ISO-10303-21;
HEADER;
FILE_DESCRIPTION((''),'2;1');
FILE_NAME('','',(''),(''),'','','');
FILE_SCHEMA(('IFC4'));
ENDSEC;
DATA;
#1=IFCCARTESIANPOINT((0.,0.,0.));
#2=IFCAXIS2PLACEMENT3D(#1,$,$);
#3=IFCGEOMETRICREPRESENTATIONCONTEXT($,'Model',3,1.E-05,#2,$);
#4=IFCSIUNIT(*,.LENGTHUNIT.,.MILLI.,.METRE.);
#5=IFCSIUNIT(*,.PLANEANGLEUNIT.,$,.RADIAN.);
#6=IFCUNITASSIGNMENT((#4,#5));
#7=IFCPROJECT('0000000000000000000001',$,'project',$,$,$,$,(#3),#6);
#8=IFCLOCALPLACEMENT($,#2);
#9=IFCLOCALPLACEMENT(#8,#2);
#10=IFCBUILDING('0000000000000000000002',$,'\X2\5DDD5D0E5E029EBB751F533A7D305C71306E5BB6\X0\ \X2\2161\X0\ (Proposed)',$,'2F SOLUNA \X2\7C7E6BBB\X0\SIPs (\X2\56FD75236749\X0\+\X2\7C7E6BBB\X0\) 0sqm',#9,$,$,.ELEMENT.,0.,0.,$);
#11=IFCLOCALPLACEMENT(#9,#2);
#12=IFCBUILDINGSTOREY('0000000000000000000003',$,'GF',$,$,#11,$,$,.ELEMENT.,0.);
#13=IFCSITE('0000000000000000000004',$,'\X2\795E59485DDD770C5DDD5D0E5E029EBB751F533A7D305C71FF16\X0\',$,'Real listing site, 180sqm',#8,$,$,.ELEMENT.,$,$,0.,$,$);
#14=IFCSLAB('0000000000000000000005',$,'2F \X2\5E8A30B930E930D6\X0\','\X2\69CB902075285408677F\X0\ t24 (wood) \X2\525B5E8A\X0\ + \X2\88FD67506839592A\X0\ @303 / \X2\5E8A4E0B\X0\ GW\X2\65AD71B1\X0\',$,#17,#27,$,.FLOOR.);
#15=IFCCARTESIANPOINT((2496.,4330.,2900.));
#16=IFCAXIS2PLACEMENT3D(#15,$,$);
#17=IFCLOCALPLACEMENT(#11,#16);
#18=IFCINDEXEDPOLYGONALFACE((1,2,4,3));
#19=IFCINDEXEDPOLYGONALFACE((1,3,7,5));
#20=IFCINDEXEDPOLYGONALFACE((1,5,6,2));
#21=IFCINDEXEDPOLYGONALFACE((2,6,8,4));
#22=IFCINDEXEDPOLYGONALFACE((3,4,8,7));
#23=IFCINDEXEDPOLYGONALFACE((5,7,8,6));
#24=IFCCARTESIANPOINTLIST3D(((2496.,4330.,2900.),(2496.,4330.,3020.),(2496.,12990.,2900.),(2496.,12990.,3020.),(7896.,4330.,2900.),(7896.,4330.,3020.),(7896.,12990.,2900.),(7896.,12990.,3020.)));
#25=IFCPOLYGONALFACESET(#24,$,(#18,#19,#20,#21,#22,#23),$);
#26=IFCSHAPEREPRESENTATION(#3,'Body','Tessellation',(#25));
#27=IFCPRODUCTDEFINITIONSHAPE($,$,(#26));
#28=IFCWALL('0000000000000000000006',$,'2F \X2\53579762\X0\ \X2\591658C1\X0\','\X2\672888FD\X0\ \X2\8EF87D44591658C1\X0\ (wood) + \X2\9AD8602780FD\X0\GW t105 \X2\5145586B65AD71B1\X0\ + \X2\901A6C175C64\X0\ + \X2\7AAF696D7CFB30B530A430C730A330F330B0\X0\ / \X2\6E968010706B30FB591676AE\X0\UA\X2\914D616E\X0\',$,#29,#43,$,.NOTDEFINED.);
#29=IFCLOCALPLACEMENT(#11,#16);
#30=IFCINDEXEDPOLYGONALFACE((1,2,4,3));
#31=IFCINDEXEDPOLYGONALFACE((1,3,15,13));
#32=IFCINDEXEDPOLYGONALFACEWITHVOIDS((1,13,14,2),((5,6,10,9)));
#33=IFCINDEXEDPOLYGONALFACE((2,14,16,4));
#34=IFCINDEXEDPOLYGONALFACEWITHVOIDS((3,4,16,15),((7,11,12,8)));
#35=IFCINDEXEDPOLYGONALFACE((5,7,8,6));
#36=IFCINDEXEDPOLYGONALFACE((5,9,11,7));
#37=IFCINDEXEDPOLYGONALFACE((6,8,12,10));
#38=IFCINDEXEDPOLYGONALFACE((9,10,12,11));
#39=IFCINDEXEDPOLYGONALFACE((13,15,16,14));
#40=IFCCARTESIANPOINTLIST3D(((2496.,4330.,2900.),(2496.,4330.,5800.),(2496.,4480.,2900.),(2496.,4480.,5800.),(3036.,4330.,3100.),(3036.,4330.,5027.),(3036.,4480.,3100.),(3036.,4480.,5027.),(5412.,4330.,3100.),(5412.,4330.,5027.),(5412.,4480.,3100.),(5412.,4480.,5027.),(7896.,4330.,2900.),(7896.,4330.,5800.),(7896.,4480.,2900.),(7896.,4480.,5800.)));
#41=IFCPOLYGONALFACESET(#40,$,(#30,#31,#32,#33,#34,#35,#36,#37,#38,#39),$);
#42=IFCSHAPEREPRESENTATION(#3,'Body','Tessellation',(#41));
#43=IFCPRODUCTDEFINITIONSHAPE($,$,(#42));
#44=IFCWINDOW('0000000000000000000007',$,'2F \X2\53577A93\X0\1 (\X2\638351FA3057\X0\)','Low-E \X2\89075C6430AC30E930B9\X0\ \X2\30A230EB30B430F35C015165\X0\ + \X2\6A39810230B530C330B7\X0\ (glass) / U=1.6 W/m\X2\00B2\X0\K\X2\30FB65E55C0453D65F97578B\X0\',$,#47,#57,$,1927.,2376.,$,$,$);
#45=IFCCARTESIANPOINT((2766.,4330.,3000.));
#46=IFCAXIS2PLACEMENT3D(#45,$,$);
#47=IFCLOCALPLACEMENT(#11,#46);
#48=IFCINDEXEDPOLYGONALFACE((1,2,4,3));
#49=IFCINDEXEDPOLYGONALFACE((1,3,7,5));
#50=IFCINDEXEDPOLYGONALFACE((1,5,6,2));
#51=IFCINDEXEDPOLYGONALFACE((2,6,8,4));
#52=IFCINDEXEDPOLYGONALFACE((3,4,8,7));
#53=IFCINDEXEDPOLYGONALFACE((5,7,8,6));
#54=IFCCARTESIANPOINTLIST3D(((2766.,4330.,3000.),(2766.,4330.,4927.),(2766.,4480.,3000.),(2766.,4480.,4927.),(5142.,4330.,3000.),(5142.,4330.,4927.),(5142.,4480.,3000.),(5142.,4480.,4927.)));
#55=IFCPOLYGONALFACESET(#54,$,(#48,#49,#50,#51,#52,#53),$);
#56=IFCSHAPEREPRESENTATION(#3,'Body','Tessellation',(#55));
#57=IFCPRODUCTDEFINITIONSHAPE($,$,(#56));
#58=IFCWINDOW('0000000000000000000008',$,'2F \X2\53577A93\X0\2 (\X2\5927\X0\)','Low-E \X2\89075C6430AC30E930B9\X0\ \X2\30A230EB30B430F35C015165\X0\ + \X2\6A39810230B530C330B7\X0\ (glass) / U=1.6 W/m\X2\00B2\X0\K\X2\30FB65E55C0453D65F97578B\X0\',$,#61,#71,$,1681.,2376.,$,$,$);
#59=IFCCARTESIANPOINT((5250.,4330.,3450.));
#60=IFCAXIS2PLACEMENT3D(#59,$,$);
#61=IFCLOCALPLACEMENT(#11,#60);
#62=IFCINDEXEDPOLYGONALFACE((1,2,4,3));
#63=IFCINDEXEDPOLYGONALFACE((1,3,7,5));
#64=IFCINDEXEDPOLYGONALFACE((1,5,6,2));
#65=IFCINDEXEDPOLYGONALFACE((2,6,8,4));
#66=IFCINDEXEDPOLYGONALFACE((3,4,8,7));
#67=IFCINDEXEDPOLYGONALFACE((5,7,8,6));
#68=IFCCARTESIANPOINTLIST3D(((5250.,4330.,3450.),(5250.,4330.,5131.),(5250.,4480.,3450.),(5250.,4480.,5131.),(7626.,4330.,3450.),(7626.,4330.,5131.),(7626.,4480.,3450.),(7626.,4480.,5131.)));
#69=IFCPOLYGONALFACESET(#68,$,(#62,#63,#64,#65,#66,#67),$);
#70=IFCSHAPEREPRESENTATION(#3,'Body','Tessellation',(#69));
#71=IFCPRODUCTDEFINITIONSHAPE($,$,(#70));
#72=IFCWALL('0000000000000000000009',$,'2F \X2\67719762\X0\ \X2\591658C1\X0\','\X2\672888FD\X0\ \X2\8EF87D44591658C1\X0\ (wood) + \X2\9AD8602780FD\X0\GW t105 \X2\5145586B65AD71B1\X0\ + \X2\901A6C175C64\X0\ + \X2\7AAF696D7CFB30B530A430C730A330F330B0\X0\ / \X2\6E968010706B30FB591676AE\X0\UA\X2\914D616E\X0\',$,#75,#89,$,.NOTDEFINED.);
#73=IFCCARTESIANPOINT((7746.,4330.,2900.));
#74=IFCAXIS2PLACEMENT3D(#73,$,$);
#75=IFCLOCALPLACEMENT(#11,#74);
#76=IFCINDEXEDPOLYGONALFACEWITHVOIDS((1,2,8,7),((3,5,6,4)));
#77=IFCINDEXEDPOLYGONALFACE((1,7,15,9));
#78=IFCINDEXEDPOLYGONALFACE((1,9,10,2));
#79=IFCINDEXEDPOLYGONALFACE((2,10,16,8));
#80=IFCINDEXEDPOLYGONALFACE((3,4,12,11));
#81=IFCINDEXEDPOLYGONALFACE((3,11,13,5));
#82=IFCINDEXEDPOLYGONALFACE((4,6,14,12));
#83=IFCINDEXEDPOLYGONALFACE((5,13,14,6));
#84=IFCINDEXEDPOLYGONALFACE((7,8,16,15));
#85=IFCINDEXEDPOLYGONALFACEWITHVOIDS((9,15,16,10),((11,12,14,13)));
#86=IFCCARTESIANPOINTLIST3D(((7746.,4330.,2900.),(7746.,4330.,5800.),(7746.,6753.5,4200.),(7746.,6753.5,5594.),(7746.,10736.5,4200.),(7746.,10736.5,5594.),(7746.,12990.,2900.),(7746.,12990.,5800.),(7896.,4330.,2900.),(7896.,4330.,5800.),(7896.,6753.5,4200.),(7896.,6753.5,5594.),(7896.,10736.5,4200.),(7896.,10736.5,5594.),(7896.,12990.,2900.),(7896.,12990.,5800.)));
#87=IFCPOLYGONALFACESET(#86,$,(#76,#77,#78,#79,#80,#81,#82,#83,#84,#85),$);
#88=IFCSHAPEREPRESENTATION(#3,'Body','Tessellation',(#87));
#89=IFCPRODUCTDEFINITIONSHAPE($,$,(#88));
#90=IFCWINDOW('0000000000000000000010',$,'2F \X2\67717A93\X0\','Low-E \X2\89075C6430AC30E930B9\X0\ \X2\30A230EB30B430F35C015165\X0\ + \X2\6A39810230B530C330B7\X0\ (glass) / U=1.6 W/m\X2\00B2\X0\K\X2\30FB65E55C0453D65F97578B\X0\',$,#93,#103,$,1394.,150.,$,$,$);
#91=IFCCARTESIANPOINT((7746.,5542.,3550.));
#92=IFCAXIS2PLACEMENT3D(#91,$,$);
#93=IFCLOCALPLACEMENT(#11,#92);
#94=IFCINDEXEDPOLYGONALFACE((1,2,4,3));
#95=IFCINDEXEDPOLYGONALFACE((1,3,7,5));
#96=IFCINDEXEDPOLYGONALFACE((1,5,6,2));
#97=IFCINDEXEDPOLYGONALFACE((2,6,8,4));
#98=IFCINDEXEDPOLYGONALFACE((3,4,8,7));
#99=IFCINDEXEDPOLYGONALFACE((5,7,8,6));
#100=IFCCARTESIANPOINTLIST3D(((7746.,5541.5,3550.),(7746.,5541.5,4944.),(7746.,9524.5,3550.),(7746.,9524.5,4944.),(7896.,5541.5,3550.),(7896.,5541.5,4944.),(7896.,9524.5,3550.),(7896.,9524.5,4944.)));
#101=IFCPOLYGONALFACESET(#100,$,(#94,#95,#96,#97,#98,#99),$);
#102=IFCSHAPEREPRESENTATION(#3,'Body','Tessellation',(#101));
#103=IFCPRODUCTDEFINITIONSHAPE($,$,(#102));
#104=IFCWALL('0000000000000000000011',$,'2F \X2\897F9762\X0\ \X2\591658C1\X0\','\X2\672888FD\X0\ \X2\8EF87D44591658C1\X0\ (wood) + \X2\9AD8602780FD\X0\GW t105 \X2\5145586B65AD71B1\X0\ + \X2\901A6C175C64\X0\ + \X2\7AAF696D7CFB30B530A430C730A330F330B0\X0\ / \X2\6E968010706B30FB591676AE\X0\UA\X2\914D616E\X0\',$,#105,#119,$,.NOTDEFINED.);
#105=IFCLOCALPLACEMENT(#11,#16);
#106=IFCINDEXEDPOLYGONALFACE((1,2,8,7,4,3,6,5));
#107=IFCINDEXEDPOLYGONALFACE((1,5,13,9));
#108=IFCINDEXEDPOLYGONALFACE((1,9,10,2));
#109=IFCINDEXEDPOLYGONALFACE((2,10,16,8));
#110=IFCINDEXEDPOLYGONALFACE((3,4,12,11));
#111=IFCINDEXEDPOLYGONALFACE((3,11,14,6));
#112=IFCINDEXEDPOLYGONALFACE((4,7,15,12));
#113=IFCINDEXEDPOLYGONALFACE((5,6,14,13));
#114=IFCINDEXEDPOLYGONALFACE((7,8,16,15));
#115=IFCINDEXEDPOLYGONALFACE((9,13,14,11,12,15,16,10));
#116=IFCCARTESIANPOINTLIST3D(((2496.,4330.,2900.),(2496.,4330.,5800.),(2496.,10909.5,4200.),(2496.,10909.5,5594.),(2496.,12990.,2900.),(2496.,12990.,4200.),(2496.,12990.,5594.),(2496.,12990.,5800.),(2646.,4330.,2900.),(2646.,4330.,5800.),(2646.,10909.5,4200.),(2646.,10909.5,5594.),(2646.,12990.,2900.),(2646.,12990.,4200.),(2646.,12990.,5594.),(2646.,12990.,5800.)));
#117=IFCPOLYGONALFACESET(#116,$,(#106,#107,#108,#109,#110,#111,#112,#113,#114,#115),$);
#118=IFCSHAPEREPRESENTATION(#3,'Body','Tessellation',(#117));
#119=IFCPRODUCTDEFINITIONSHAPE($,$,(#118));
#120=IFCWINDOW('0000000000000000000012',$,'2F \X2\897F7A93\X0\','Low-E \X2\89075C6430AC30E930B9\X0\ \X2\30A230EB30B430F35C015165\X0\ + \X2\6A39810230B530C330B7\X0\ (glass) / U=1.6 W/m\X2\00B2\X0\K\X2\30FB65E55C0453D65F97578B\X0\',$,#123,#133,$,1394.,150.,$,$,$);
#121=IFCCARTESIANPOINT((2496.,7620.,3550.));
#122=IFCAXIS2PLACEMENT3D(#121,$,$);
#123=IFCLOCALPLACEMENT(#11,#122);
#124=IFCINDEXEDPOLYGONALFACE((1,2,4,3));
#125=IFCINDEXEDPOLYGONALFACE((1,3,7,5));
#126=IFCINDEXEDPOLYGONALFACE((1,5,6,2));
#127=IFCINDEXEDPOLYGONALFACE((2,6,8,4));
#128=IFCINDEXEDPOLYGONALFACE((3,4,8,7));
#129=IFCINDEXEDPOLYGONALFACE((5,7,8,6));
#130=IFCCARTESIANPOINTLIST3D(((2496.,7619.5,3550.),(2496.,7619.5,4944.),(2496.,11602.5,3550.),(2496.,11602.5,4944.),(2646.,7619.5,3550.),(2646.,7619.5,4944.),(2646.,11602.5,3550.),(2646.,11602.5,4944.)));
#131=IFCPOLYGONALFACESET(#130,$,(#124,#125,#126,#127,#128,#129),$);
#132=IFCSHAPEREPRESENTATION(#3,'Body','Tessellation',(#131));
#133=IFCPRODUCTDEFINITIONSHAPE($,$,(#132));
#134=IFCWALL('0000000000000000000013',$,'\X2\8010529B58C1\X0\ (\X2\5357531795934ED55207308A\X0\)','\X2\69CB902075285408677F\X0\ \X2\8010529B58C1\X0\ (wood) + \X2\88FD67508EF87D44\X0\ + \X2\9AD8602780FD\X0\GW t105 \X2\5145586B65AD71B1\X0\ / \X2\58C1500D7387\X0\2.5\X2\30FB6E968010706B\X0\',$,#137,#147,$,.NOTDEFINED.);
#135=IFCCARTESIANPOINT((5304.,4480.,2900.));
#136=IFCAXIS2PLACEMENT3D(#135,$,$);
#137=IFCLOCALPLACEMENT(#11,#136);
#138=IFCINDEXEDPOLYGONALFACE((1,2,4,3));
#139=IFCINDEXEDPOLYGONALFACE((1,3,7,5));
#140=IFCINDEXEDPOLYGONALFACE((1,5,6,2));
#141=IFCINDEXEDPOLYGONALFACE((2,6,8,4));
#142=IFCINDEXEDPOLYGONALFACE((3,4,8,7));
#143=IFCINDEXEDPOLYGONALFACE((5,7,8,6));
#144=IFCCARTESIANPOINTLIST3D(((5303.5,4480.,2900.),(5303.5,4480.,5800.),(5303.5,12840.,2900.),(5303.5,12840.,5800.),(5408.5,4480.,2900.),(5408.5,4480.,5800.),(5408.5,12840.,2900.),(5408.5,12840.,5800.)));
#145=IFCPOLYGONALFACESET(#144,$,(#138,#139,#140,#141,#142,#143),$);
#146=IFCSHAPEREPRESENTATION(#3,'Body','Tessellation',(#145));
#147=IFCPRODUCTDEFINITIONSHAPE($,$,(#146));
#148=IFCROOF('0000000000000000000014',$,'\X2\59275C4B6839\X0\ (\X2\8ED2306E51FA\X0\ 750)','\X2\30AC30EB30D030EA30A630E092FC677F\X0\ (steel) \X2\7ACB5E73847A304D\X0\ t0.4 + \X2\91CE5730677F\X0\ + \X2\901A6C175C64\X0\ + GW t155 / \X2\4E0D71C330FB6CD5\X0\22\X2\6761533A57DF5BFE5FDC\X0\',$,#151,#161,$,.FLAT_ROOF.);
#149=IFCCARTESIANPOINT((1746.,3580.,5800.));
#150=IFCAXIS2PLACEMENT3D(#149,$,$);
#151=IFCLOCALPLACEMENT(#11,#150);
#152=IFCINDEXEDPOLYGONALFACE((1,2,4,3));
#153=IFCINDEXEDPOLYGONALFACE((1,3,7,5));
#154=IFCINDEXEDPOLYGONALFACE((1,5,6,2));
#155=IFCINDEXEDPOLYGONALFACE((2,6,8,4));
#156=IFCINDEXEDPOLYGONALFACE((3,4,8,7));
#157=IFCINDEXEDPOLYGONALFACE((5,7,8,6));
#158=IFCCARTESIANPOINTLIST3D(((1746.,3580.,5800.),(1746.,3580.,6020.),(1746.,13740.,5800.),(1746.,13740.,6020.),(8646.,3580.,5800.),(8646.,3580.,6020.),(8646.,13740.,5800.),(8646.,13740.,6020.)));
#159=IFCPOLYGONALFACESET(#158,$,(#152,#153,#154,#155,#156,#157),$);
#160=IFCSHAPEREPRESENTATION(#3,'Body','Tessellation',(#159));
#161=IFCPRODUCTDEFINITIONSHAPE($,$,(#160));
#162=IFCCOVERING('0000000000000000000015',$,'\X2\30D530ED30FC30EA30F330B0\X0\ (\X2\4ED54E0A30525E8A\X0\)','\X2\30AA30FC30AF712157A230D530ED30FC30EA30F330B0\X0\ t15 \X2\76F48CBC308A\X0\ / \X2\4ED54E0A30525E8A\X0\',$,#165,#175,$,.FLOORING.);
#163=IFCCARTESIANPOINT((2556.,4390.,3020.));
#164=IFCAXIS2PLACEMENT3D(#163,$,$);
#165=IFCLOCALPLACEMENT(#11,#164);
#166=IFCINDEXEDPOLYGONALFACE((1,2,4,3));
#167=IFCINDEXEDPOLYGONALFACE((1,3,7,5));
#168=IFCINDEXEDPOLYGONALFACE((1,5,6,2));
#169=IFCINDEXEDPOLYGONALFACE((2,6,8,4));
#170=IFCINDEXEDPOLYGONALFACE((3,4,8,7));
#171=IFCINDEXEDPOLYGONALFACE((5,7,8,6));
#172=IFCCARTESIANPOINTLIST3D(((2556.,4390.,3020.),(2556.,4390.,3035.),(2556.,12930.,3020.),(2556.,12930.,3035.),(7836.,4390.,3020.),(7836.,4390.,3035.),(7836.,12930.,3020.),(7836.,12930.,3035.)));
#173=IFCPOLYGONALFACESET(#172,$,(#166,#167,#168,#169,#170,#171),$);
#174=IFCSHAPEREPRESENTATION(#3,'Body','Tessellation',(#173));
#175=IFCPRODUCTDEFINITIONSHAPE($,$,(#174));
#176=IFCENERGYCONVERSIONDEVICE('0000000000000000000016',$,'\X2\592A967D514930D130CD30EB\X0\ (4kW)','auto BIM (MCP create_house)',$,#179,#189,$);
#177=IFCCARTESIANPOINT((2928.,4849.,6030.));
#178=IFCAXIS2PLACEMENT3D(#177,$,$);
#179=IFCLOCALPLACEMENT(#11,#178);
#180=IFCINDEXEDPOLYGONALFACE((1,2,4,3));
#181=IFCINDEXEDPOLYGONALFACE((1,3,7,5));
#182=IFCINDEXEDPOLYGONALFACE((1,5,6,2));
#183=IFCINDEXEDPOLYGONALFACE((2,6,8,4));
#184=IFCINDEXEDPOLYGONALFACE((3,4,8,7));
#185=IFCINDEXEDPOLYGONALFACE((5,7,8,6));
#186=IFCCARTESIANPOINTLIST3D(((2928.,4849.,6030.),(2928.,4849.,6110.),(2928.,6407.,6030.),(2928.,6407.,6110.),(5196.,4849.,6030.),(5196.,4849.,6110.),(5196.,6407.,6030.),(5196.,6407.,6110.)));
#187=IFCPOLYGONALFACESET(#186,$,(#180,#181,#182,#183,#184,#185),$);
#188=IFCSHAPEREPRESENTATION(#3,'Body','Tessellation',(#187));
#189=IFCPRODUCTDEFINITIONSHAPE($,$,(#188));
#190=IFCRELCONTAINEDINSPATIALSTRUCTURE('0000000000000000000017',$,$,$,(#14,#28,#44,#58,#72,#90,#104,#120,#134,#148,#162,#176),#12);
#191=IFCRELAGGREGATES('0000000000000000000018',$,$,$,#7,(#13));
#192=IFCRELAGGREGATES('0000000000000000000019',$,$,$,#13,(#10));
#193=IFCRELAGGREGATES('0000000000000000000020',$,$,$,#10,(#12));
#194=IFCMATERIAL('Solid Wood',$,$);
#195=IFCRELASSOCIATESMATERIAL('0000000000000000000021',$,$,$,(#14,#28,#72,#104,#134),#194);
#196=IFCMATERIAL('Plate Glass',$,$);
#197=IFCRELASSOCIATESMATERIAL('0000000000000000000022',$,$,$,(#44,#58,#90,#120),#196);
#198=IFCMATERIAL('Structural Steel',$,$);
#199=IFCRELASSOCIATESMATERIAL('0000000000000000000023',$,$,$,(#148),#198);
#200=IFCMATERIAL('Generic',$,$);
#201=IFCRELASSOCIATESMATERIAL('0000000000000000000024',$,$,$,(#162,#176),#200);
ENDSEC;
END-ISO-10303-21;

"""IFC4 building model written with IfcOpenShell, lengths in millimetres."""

from ifc_helpers import new_model, si_unit, frame, frame_2d, origin, place, context, project, spatial, rectangle, extrude, material, element, fill, save


model = new_model("IFC4")

# Units and contexts
model_context = context("Model", 3, precision=1e-05, world=origin())
ifc_project = project(units=[si_unit("LENGTHUNIT", "METRE", prefix="MILLI"), si_unit("PLANEANGLEUNIT", "RADIAN")], contexts=[model_context])

# Site, building, storey
site_placement = place(None, origin())
site = spatial("IfcSite", under=ifc_project, at=site_placement, Name="神奈川県川崎市麻生区細山６", ObjectType="Real listing site, 180sqm", CompositionType="ELEMENT", RefElevation=0.0)
building_placement = place(site_placement, origin())
building = spatial("IfcBuilding", under=site, at=building_placement, Name="川崎市麻生区細山の家 Ⅱ (Proposed)", ObjectType="2F SOLUNA 籾殻SIPs (国産杉+籾殻) 0sqm", CompositionType="ELEMENT", ElevationOfRefHeight=0.0, ElevationOfTerrain=0.0)
storey_placement = place(building_placement, origin())
storey = spatial("IfcBuildingStorey", under=building, at=storey_placement, Name="GF", CompositionType="ELEMENT", Elevation=0.0)

# Slab
ifc_material_1 = material(Name="Solid Wood")
slab_placement = place(storey_placement, frame((2496.0, 4330.0, 2900.0)))
element("IfcSlab", 1, at=slab_placement, inside=storey, material=ifc_material_1, Name="2F 床スラブ", Description="構造用合板 t24 (wood) 剛床 + 製材根太 @303 / 床下 GW断熱", PredefinedType="FLOOR", context=model_context, shape_type="SweptSolid", body=[
    extrude(rectangle(XDim=5400.0, YDim=8660.0, at=frame_2d((2700.0, 4330.0))), frame((2496.0, 4330.0, 2900.0)), (0.0, 0.0, 1.0), 120.0),
])

# Wall, openings, windows
wall_1_placement = place(storey_placement, frame((2496.0, 4330.0, 2900.0)))
wall_1 = element("IfcWall", 2, at=wall_1_placement, inside=storey, material=ifc_material_1, Name="2F 南面 外壁", Description="木製 軸組外壁 (wood) + 高性能GW t105 充填断熱 + 通気層 + 窯業系サイディング / 準耐火・外皮UA配慮", PredefinedType="NOTDEFINED", context=model_context, shape_type="SweptSolid", body=[
    extrude(rectangle(XDim=5400.0, YDim=150.0, at=frame_2d((2700.0, 75.0))), frame((2496.0, 4330.0, 2900.0)), (0.0, 0.0, 1.0), 2900.0),
])
opening_1_placement = place(storey_placement, frame((2766.0, 4330.0, 3000.0)))
opening_1 = element("IfcOpeningElement", 3, at=opening_1_placement, cuts=wall_1, PredefinedType="NOTDEFINED", context=model_context, shape_type="SweptSolid", body=[
    extrude(rectangle(XDim=2376.0, YDim=150.0, at=frame_2d((1188.0, 75.0))), frame((2766.0, 4330.0, 3000.0)), (0.0, 0.0, 1.0), 1927.0),
])
opening_2_placement = place(storey_placement, frame((5250.0, 4330.0, 3450.0)))
opening_2 = element("IfcOpeningElement", 4, at=opening_2_placement, cuts=wall_1, PredefinedType="NOTDEFINED", context=model_context, shape_type="SweptSolid", body=[
    extrude(rectangle(XDim=2376.0, YDim=150.0, at=frame_2d((1188.0, 75.0))), frame((5250.0, 4330.0, 3450.0)), (0.0, 0.0, 1.0), 1681.0),
])
ifc_material_2 = material(Name="Plate Glass")
window_1_placement = place(storey_placement, frame((2766.0, 4330.0, 3000.0)))
window_1 = element("IfcWindow", 5, at=window_1_placement, inside=storey, material=ifc_material_2, Name="2F 南窓1 (掃出し)", Description="Low-E 複層ガラス アルゴン封入 + 樹脂サッシ (glass) / U=1.6 W/m²K・日射取得型", OverallHeight=1927.0, OverallWidth=2376.0, context=model_context, shape_type="SweptSolid", body=[
    extrude(rectangle(XDim=2376.0, YDim=150.0, at=frame_2d((1188.0, 75.0))), frame((2766.0, 4330.0, 3000.0)), (0.0, 0.0, 1.0), 1927.0),
])
fill(opening_1, window_1)
window_2_placement = place(storey_placement, frame((5250.0, 4330.0, 3450.0)))
window_2 = element("IfcWindow", 6, at=window_2_placement, inside=storey, material=ifc_material_2, Name="2F 南窓2 (大)", Description="Low-E 複層ガラス アルゴン封入 + 樹脂サッシ (glass) / U=1.6 W/m²K・日射取得型", OverallHeight=1681.0, OverallWidth=2376.0, context=model_context, shape_type="SweptSolid", body=[
    extrude(rectangle(XDim=2376.0, YDim=150.0, at=frame_2d((1188.0, 75.0))), frame((5250.0, 4330.0, 3450.0)), (0.0, 0.0, 1.0), 1681.0),
])
fill(opening_2, window_2)

# Walls, openings, windows
wall_2_placement = place(storey_placement, frame((7746.0, 4330.0, 2900.0)))
wall_2 = element("IfcWall", 7, at=wall_2_placement, inside=storey, material=ifc_material_1, Name="2F 東面 外壁", Description="木製 軸組外壁 (wood) + 高性能GW t105 充填断熱 + 通気層 + 窯業系サイディング / 準耐火・外皮UA配慮", PredefinedType="NOTDEFINED", context=model_context, shape_type="SweptSolid", body=[
    extrude(rectangle(XDim=150.0, YDim=8660.0, at=frame_2d((75.0, 4330.0))), frame((7746.0, 4330.0, 2900.0)), (0.0, 0.0, 1.0), 2900.0),
])
opening_3_placement = place(storey_placement, frame((7746.0, 5542.0, 3550.0)))
opening_3 = element("IfcOpeningElement", 8, at=opening_3_placement, cuts=wall_2, PredefinedType="NOTDEFINED", context=model_context, shape_type="SweptSolid", body=[
    extrude(rectangle(XDim=150.0, YDim=3983.0, at=frame_2d((75.0, 1991.0))), frame((7746.0, 5542.0, 3550.0)), (0.0, 0.0, 1.0), 1394.0),
])
window_3_placement = place(storey_placement, frame((7746.0, 5542.0, 3550.0)))
window_3 = element("IfcWindow", 9, at=window_3_placement, inside=storey, material=ifc_material_2, Name="2F 東窓", Description="Low-E 複層ガラス アルゴン封入 + 樹脂サッシ (glass) / U=1.6 W/m²K・日射取得型", OverallHeight=1394.0, OverallWidth=150.0, context=model_context, shape_type="SweptSolid", body=[
    extrude(rectangle(XDim=150.0, YDim=3983.0, at=frame_2d((75.0, 1991.0))), frame((7746.0, 5542.0, 3550.0)), (0.0, 0.0, 1.0), 1394.0),
])
fill(opening_3, window_3)
wall_3_placement = place(storey_placement, frame((2496.0, 4330.0, 2900.0)))
wall_3 = element("IfcWall", 10, at=wall_3_placement, inside=storey, material=ifc_material_1, Name="2F 西面 外壁", Description="木製 軸組外壁 (wood) + 高性能GW t105 充填断熱 + 通気層 + 窯業系サイディング / 準耐火・外皮UA配慮", PredefinedType="NOTDEFINED", context=model_context, shape_type="SweptSolid", body=[
    extrude(rectangle(XDim=150.0, YDim=8660.0, at=frame_2d((75.0, 4330.0))), frame((2496.0, 4330.0, 2900.0)), (0.0, 0.0, 1.0), 2900.0),
])
opening_4_placement = place(storey_placement, frame((2496.0, 7620.0, 3550.0)))
opening_4 = element("IfcOpeningElement", 11, at=opening_4_placement, cuts=wall_3, PredefinedType="NOTDEFINED", context=model_context, shape_type="SweptSolid", body=[
    extrude(rectangle(XDim=150.0, YDim=3983.0, at=frame_2d((75.0, 1991.0))), frame((2496.0, 7620.0, 3550.0)), (0.0, 0.0, 1.0), 1394.0),
])
window_4_placement = place(storey_placement, frame((2496.0, 7620.0, 3550.0)))
window_4 = element("IfcWindow", 12, at=window_4_placement, inside=storey, material=ifc_material_2, Name="2F 西窓", Description="Low-E 複層ガラス アルゴン封入 + 樹脂サッシ (glass) / U=1.6 W/m²K・日射取得型", OverallHeight=1394.0, OverallWidth=150.0, context=model_context, shape_type="SweptSolid", body=[
    extrude(rectangle(XDim=150.0, YDim=3983.0, at=frame_2d((75.0, 1991.0))), frame((2496.0, 7620.0, 3550.0)), (0.0, 0.0, 1.0), 1394.0),
])
fill(opening_4, window_4)

# Wall
wall_4_placement = place(storey_placement, frame((5304.0, 4480.0, 2900.0)))
element("IfcWall", 13, at=wall_4_placement, inside=storey, material=ifc_material_1, Name="耐力壁 (南北間仕切り)", Description="構造用合板 耐力壁 (wood) + 製材軸組 + 高性能GW t105 充填断熱 / 壁倍率2.5・準耐火", PredefinedType="NOTDEFINED", context=model_context, shape_type="SweptSolid", body=[
    extrude(rectangle(XDim=105.0, YDim=8360.0, at=frame_2d((52.0, 4180.0))), frame((5304.0, 4480.0, 2900.0)), (0.0, 0.0, 1.0), 2900.0),
])

# Roof
ifc_material_3 = material(Name="Structural Steel")
roof_placement = place(storey_placement, frame((1746.0, 3580.0, 5800.0)))
element("IfcRoof", 14, at=roof_placement, inside=storey, material=ifc_material_3, Name="大屋根 (軒の出 750)", Description="ガルバリウム鋼板 (steel) 立平葺き t0.4 + 野地板 + 通気層 + GW t155 / 不燃・法22条区域対応", PredefinedType="FLAT_ROOF", context=model_context, shape_type="SweptSolid", body=[
    extrude(rectangle(XDim=6900.0, YDim=10160.0, at=frame_2d((3450.0, 5080.0))), frame((1746.0, 3580.0, 5800.0)), (0.0, 0.0, 1.0), 220.0),
])

# Covering
ifc_material_4 = material(Name="Generic")
covering_placement = place(storey_placement, frame((2556.0, 4390.0, 3020.0)))
element("IfcCovering", 15, at=covering_placement, inside=storey, material=ifc_material_4, Name="フローリング (仕上げ床)", Description="オーク無垢フローリング t15 直貼り / 仕上げ床", PredefinedType="FLOORING", context=model_context, shape_type="SweptSolid", body=[
    extrude(rectangle(XDim=5280.0, YDim=8540.0, at=frame_2d((2640.0, 4270.0))), frame((2556.0, 4390.0, 3020.0)), (0.0, 0.0, 1.0), 15.0),
])

# Energy conversion device
energy_conversion_device_placement = place(storey_placement, frame((2928.0, 4849.0, 6030.0)))
element("IfcEnergyConversionDevice", 16, at=energy_conversion_device_placement, inside=storey, material=ifc_material_4, Name="太陽光パネル (4kW)", Description="auto BIM (MCP create_house)", context=model_context, shape_type="SweptSolid", body=[
    extrude(rectangle(XDim=2268.0, YDim=1558.0, at=frame_2d((1134.0, 779.0))), frame((2928.0, 4849.0, 6030.0)), (0.0, 0.0, 1.0), 80.0),
])

save(model, "model.ifc")
